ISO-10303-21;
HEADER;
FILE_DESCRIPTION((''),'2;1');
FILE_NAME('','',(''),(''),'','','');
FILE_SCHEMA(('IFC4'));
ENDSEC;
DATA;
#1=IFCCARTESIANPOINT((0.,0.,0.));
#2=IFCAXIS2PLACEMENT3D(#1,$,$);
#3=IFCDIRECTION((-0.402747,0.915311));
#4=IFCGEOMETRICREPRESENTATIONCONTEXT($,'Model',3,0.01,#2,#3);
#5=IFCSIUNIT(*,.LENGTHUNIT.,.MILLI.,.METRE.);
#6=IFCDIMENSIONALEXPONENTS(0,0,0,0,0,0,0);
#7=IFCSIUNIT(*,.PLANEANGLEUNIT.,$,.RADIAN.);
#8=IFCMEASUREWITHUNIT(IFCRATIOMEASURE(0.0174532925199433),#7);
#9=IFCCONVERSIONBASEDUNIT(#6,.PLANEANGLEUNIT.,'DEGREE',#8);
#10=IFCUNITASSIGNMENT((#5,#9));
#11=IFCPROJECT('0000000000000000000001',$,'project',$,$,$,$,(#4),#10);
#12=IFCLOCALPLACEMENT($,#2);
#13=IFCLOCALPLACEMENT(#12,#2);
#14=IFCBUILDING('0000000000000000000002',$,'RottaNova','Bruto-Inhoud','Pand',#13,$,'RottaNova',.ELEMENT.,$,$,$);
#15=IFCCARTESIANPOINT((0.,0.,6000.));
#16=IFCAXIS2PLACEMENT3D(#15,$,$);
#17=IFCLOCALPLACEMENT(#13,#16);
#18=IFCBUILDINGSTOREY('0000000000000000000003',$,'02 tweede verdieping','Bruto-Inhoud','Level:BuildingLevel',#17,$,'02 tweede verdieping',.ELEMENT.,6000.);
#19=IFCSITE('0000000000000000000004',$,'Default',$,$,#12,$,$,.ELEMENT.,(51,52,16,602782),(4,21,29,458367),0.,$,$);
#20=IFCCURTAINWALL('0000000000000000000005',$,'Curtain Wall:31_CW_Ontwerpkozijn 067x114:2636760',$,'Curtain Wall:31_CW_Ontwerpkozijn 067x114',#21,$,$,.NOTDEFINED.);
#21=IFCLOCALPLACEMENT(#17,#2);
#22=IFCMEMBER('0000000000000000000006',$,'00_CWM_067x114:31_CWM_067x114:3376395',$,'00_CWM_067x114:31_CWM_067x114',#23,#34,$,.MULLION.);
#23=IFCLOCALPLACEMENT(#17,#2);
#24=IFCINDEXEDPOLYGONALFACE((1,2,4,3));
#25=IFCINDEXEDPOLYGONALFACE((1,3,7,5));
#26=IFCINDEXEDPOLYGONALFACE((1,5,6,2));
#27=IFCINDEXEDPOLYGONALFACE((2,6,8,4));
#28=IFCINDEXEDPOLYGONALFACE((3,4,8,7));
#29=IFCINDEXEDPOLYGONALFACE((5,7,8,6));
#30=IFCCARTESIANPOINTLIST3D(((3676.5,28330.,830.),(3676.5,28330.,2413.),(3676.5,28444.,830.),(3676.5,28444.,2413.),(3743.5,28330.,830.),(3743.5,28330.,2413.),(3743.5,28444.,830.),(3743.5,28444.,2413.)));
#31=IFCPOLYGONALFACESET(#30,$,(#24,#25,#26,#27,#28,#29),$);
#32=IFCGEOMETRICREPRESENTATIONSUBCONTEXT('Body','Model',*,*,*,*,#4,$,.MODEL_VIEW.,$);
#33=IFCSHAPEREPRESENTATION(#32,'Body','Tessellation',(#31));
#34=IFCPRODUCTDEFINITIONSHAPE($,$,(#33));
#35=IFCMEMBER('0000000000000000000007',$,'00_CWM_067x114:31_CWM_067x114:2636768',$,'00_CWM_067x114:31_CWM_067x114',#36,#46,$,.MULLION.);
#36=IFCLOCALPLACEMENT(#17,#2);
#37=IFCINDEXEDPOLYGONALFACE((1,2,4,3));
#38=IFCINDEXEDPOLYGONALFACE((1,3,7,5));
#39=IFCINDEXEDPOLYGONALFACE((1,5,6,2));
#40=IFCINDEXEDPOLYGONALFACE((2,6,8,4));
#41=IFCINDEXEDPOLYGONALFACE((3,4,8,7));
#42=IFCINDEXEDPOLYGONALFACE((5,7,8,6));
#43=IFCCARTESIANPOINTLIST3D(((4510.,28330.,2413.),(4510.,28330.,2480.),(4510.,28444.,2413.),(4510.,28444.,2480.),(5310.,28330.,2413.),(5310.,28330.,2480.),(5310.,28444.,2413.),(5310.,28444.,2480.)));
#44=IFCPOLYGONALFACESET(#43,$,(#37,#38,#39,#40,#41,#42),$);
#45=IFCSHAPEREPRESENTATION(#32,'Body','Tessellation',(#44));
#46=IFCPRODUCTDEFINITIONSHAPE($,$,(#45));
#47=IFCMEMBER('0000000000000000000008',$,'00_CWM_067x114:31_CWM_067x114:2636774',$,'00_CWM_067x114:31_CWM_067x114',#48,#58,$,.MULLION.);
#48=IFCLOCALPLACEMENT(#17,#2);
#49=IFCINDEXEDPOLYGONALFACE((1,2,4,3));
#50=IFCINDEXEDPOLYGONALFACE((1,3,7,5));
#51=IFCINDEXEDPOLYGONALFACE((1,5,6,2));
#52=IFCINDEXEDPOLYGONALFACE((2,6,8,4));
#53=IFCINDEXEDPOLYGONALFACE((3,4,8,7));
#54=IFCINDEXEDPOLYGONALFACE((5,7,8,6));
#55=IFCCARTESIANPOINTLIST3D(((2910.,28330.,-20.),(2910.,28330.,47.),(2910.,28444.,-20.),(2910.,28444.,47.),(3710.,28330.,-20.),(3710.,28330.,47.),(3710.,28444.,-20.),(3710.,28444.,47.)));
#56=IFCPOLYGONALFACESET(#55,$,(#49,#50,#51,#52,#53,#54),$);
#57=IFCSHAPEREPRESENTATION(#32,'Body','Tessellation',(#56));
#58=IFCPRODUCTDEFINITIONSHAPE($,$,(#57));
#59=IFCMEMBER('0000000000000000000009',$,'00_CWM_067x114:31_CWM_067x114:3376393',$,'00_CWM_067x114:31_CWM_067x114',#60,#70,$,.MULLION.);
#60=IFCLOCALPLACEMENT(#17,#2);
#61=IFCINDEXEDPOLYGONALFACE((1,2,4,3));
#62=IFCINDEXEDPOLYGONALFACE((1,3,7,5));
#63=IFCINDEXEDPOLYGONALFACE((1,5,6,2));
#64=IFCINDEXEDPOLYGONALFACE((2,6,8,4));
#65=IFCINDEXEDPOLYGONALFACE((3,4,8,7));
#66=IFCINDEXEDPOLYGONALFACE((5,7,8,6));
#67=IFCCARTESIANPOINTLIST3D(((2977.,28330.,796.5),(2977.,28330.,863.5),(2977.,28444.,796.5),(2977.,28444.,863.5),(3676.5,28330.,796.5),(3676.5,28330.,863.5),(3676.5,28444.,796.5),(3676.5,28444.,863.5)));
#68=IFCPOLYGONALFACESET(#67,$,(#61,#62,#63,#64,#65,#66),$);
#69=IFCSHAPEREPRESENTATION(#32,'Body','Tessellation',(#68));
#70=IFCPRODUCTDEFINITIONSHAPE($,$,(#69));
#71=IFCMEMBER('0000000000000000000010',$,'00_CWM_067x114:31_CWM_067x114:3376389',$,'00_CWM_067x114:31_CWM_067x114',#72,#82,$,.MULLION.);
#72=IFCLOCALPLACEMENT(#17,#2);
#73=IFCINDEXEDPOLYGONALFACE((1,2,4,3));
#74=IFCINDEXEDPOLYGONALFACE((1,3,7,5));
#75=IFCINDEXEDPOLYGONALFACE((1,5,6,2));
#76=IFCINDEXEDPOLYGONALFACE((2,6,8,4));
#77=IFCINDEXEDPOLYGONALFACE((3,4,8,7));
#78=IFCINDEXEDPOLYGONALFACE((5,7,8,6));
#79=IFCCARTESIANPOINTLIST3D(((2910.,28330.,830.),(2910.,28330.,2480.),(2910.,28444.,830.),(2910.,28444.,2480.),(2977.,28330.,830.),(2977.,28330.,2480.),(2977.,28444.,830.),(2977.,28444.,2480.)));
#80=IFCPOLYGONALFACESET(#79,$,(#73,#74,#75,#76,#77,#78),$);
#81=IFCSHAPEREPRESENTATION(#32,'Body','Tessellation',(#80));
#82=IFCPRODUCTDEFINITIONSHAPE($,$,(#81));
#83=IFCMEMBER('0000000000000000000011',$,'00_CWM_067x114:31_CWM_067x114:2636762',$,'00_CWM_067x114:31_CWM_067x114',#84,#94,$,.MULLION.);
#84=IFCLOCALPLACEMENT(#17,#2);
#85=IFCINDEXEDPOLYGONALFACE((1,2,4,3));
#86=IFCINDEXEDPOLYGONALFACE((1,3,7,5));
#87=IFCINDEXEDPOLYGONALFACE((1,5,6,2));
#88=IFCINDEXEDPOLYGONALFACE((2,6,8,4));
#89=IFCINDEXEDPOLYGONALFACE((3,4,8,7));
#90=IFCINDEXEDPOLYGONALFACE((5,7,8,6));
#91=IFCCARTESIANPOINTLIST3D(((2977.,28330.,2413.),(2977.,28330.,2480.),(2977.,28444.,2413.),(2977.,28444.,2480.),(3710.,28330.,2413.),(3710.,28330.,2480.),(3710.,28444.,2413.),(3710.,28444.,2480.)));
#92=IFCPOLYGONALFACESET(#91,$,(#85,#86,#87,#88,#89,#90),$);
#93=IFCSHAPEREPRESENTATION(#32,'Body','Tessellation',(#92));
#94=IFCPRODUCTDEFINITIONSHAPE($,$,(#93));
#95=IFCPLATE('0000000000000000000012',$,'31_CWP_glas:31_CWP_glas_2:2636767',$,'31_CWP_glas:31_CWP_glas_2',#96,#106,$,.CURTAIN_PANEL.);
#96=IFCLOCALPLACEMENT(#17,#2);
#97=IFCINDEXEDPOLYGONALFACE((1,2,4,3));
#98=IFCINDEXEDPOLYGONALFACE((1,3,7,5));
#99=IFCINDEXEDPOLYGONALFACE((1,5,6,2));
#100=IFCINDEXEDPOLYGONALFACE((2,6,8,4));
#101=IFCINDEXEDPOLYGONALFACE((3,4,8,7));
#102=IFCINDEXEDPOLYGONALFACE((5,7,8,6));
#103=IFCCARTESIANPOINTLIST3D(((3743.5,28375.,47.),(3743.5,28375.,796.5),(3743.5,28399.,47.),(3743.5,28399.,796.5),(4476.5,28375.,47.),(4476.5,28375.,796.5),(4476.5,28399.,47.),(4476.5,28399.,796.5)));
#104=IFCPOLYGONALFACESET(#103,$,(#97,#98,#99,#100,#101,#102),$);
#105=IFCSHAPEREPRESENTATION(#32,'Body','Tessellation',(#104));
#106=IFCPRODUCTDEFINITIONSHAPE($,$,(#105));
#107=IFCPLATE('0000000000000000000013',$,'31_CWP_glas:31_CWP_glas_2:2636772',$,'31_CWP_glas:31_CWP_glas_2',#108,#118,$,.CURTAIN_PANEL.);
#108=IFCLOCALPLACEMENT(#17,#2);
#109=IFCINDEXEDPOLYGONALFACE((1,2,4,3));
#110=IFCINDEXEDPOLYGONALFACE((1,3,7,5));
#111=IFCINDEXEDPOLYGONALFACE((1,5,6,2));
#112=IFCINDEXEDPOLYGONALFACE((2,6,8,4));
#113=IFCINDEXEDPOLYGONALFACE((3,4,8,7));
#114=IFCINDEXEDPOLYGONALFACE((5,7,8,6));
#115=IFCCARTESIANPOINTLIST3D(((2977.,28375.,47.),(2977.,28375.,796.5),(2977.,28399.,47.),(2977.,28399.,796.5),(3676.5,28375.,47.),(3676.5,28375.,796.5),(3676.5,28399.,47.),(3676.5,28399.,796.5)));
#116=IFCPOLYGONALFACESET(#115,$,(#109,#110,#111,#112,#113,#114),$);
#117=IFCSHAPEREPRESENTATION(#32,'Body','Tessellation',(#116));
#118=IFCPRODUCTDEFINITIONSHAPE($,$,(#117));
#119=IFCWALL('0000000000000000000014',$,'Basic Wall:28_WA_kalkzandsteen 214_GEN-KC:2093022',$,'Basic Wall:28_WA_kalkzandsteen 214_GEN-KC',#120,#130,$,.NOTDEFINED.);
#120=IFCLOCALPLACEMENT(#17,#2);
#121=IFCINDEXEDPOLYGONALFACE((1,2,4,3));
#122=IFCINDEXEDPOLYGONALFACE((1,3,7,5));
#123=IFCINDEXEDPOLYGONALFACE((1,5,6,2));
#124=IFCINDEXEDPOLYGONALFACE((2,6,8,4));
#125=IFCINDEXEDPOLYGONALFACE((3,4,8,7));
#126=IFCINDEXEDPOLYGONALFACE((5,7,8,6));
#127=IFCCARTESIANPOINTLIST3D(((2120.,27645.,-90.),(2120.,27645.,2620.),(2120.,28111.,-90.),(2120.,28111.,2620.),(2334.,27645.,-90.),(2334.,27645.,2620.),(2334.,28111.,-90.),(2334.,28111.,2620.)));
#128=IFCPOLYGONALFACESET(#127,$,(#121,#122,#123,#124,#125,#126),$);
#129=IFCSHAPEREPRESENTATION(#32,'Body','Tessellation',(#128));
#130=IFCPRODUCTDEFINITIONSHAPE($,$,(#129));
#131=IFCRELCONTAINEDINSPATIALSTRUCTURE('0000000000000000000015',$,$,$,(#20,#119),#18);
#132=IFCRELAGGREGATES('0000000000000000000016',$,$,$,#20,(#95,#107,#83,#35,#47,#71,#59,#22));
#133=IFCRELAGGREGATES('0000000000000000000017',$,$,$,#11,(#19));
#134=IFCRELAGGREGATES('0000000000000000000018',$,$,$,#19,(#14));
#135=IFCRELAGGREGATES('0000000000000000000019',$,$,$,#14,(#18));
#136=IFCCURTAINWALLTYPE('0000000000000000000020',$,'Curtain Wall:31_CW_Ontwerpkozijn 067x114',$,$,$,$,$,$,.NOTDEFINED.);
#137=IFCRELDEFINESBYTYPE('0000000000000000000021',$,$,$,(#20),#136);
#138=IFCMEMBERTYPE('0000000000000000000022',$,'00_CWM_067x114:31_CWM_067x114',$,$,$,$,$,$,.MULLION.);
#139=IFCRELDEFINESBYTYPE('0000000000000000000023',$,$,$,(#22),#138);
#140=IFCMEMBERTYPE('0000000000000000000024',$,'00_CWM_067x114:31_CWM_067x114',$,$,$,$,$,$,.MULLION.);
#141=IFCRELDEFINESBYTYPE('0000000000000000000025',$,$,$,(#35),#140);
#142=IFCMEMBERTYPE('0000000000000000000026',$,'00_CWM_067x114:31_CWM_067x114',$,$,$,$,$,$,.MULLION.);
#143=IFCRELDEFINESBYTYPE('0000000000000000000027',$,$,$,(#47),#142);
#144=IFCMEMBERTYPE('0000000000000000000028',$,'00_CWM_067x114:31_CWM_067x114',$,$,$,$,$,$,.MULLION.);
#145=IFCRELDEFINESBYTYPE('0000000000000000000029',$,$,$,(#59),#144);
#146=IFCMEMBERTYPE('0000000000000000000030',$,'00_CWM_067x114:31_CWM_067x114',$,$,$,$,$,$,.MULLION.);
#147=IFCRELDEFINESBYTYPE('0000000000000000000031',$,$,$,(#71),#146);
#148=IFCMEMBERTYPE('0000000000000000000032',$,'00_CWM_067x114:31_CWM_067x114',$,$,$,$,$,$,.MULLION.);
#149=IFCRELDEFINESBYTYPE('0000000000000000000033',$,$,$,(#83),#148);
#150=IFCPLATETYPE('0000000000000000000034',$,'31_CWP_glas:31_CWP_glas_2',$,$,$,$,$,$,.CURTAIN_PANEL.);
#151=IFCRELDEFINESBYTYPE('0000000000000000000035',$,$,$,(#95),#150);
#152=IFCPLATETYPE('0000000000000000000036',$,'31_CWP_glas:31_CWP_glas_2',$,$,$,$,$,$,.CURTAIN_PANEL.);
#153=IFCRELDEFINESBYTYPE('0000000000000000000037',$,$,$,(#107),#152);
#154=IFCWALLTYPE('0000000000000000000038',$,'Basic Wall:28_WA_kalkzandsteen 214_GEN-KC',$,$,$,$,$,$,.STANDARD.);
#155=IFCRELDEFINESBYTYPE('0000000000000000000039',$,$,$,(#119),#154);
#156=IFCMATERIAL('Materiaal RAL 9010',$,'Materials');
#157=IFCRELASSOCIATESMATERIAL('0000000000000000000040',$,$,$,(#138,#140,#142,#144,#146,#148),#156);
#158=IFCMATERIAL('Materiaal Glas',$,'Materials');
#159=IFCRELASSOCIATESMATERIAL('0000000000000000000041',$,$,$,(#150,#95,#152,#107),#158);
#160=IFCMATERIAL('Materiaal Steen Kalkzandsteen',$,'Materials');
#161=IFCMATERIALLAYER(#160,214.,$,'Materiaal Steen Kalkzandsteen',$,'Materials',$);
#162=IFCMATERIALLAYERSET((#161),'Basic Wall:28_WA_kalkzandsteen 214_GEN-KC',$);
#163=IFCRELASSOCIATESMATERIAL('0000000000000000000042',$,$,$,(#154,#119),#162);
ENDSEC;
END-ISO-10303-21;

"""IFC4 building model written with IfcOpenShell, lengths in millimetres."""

from ifc_helpers import new_model, entity, si_unit, converted_unit, direction, frame, frame_2d, origin, origin_2d_with_axis, place, context, subcontext, project, spatial, rectangle, extrude, source, transform, mapped, material, layer, layer_set, material_profile, profile_set, type_object, type_shapes, element, aggregate, save


model = new_model("IFC4")

# Units and contexts
model_context = context("Model", 3, precision=0.01, world=origin(), true_north=direction((-0.402747, 0.915311)))
body_context = subcontext(model_context, "Body", "Model", "MODEL_VIEW")
ifc_project = project(units=[si_unit("LENGTHUNIT", "METRE", prefix="MILLI"), converted_unit("PLANEANGLEUNIT", "DEGREE", entity("IfcRatioMeasure", 0.0174532925199433), si_unit("PLANEANGLEUNIT", "RADIAN"), dimensions=[0, 0, 0, 0, 0, 0, 0])], contexts=[model_context])

# Site, building, storey
site_placement = place(None, origin())
site = spatial("IfcSite", under=ifc_project, at=site_placement, Name="Default", CompositionType="ELEMENT", RefLatitude=(51, 52, 16, 602782), RefLongitude=(4, 21, 29, 458367), RefElevation=0.0)
building_placement = place(site_placement, origin())
building = spatial("IfcBuilding", under=site, at=building_placement, Name="RottaNova", Description="Bruto-Inhoud", ObjectType="Pand", LongName="RottaNova", CompositionType="ELEMENT")
storey_placement = place(building_placement, frame((0.0, 0.0, 6000.0)))
storey = spatial("IfcBuildingStorey", under=building, at=storey_placement, Name="02 tweede verdieping", Description="Bruto-Inhoud", ObjectType="Level:BuildingLevel", LongName="02 tweede verdieping", CompositionType="ELEMENT", Elevation=6000.0)

# Shared definitions
curtain_wall_type = type_object("IfcCurtainWallType", Name="Curtain Wall:31_CW_Ontwerpkozijn 067x114", PredefinedType="NOTDEFINED")

# Curtain wall, members, plates
curtain_wall_1_placement = place(storey_placement, frame((0.0, 0.0, -6000.0)))
curtain_wall_1 = element("IfcCurtainWall", 1, at=curtain_wall_1_placement, inside=storey, type_object=curtain_wall_type, Name="Curtain Wall:31_CW_Ontwerpkozijn 067x114:2636760", ObjectType="Curtain Wall:31_CW_Ontwerpkozijn 067x114", PredefinedType="NOTDEFINED")
ifc_material_1 = material(Name="Materiaal RAL 9010", Category="Materials")
ifc_material_profile_1 = material_profile(ifc_material_1, rectangle(XDim=114.0, YDim=67.0, at=origin_2d_with_axis()), Name="31_CWM_067x114")
ifc_profile_set_1 = profile_set([ifc_material_profile_1], Name="31_CWM_067x114")
member_type_1 = type_object("IfcMemberType", Name="00_CWM_067x114:31_CWM_067x114", PredefinedType="MULLION", material=ifc_profile_set_1)
shared_shape_1 = source(origin(), body_context, "Body", "SweptSolid", [
    extrude(rectangle(XDim=114.0, YDim=67.0, at=origin_2d_with_axis()), frame((0.0, 57.0, -1583.0), z_axis=(0.0, 0.0, 1.0), x_axis=(0.0, -1.0, 0.0)), (0.0, 0.0, 1.0), 1583.0),
])
type_shapes(member_type_1, [shared_shape_1])
member_1_placement = place(curtain_wall_1_placement, frame((3710.0, 28330.0, 6830.0), z_axis=(0.0, 0.0, -1.0), x_axis=(-1.0, 0.0, 0.0)))
member_1 = element("IfcMember", 2, at=member_1_placement, type_object=member_type_1, Name="00_CWM_067x114:31_CWM_067x114:3376395", ObjectType="00_CWM_067x114:31_CWM_067x114", PredefinedType="MULLION", context=body_context, shape_type="MappedRepresentation", body=[
    mapped(shared_shape_1, transform((0.0, 0.0, 0.0), scale=1.0)),
])
member_type_2 = type_object("IfcMemberType", Name="00_CWM_067x114:31_CWM_067x114", PredefinedType="MULLION", material=ifc_profile_set_1)
shared_shape_2 = source(origin(), body_context, "Body", "SweptSolid", [
    extrude(rectangle(XDim=114.0, YDim=67.0, at=origin_2d_with_axis()), frame((-33.5, 57.0, -800.0), z_axis=(0.0, 0.0, 1.0), x_axis=(0.0, -1.0, 0.0)), (0.0, 0.0, 1.0), 800.0),
])
type_shapes(member_type_2, [shared_shape_2])
member_2_placement = place(curtain_wall_1_placement, frame((4510.0, 28330.0, 8480.0), z_axis=(-1.0, 0.0, 0.0), x_axis=(0.0, 0.0, 1.0)))
member_2 = element("IfcMember", 3, at=member_2_placement, type_object=member_type_2, Name="00_CWM_067x114:31_CWM_067x114:2636768", ObjectType="00_CWM_067x114:31_CWM_067x114", PredefinedType="MULLION", context=body_context, shape_type="MappedRepresentation", body=[
    mapped(shared_shape_2, transform((0.0, 0.0, 0.0), scale=1.0)),
])
member_type_3 = type_object("IfcMemberType", Name="00_CWM_067x114:31_CWM_067x114", PredefinedType="MULLION", material=ifc_profile_set_1)
shared_shape_3 = source(origin(), body_context, "Body", "SweptSolid", [
    extrude(rectangle(XDim=114.0, YDim=67.0, at=origin_2d_with_axis()), frame((-33.5, 57.0, -800.0), z_axis=(0.0, 0.0, 1.0), x_axis=(0.0, -1.0, 0.0)), (0.0, 0.0, 1.0), 800.0),
])
type_shapes(member_type_3, [shared_shape_3])
member_3_placement = place(curtain_wall_1_placement, frame((3710.0, 28330.0, 5980.0), z_axis=(1.0, 0.0, 0.0), x_axis=(0.0, 0.0, -1.0)))
member_3 = element("IfcMember", 4, at=member_3_placement, type_object=member_type_3, Name="00_CWM_067x114:31_CWM_067x114:2636774", ObjectType="00_CWM_067x114:31_CWM_067x114", PredefinedType="MULLION", context=body_context, shape_type="MappedRepresentation", body=[
    mapped(shared_shape_3, transform((0.0, 0.0, 0.0), scale=1.0)),
])
member_type_4 = type_object("IfcMemberType", Name="00_CWM_067x114:31_CWM_067x114", PredefinedType="MULLION", material=ifc_profile_set_1)
shared_shape_4 = source(origin(), body_context, "Body", "SweptSolid", [
    extrude(rectangle(XDim=114.0, YDim=67.0, at=origin_2d_with_axis()), frame((0.0, 57.0, -699.5), z_axis=(0.0, 0.0, 1.0), x_axis=(0.0, -1.0, 0.0)), (0.0, 0.0, 1.0), 699.5),
])
type_shapes(member_type_4, [shared_shape_4])
member_4_placement = place(curtain_wall_1_placement, frame((2977.0, 28330.0, 6830.0), z_axis=(-1.0, 0.0, 0.0), x_axis=(0.0, 0.0, 1.0)))
member_4 = element("IfcMember", 5, at=member_4_placement, type_object=member_type_4, Name="00_CWM_067x114:31_CWM_067x114:3376393", ObjectType="00_CWM_067x114:31_CWM_067x114", PredefinedType="MULLION", context=body_context, shape_type="MappedRepresentation", body=[
    mapped(shared_shape_4, transform((0.0, 0.0, 0.0), scale=1.0)),
])
member_type_5 = type_object("IfcMemberType", Name="00_CWM_067x114:31_CWM_067x114", PredefinedType="MULLION", material=ifc_profile_set_1)
shared_shape_5 = source(origin(), body_context, "Body", "SweptSolid", [
    extrude(rectangle(XDim=114.0, YDim=67.0, at=origin_2d_with_axis()), frame((-33.5, 57.0, -1650.0), z_axis=(0.0, 0.0, 1.0), x_axis=(0.0, -1.0, 0.0)), (0.0, 0.0, 1.0), 1650.0),
])
type_shapes(member_type_5, [shared_shape_5])
member_5_placement = place(curtain_wall_1_placement, frame((2910.0, 28330.0, 6830.0), z_axis=(0.0, 0.0, -1.0), x_axis=(-1.0, 0.0, 0.0)))
member_5 = element("IfcMember", 6, at=member_5_placement, type_object=member_type_5, Name="00_CWM_067x114:31_CWM_067x114:3376389", ObjectType="00_CWM_067x114:31_CWM_067x114", PredefinedType="MULLION", context=body_context, shape_type="MappedRepresentation", body=[
    mapped(shared_shape_5, transform((0.0, 0.0, 0.0), scale=1.0)),
])
member_type_6 = type_object("IfcMemberType", Name="00_CWM_067x114:31_CWM_067x114", PredefinedType="MULLION", material=ifc_profile_set_1)
shared_shape_6 = source(origin(), body_context, "Body", "SweptSolid", [
    extrude(rectangle(XDim=114.0, YDim=67.0, at=origin_2d_with_axis()), frame((-33.5, 57.0, -733.0), z_axis=(0.0, 0.0, 1.0), x_axis=(0.0, -1.0, 0.0)), (0.0, 0.0, 1.0), 733.0),
])
type_shapes(member_type_6, [shared_shape_6])
member_6_placement = place(curtain_wall_1_placement, frame((2977.0, 28330.0, 8480.0), z_axis=(-1.0, 0.0, 0.0), x_axis=(0.0, 0.0, 1.0)))
member_6 = element("IfcMember", 7, at=member_6_placement, type_object=member_type_6, Name="00_CWM_067x114:31_CWM_067x114:2636762", ObjectType="00_CWM_067x114:31_CWM_067x114", PredefinedType="MULLION", context=body_context, shape_type="MappedRepresentation", body=[
    mapped(shared_shape_6, transform((0.0, 0.0, 0.0), scale=1.0)),
])
ifc_material_2 = material(Name="Materiaal Glas", Category="Materials")
plate_type_1 = type_object("IfcPlateType", Name="31_CWP_glas:31_CWP_glas_2", PredefinedType="CURTAIN_PANEL", material=ifc_material_2)
shared_shape_7 = source(origin(), body_context, "Body", "SweptSolid", [
    extrude(rectangle(XDim=24.0, YDim=733.0, at=frame_2d((0.0, 0.0), x_axis=(1.0, 0.0))), frame((366.5, 12.0, 0.0), z_axis=(0.0, 0.0, 1.0), x_axis=(0.0, 1.0, 0.0)), (0.0, 0.0, 1.0), 749.5),
])
type_shapes(plate_type_1, [shared_shape_7])
plate_1_placement = place(curtain_wall_1_placement, frame((4476.5, 28399.0, 6047.0), z_axis=(0.0, 0.0, 1.0), x_axis=(-1.0, 0.0, 0.0)))
plate_1 = element("IfcPlate", 8, at=plate_1_placement, type_object=plate_type_1, material=ifc_material_2, Name="31_CWP_glas:31_CWP_glas_2:2636767", ObjectType="31_CWP_glas:31_CWP_glas_2", PredefinedType="CURTAIN_PANEL", context=body_context, shape_type="MappedRepresentation", body=[
    mapped(shared_shape_7, transform((0.0, 0.0, 0.0), scale=1.0)),
])
plate_type_2 = type_object("IfcPlateType", Name="31_CWP_glas:31_CWP_glas_2", PredefinedType="CURTAIN_PANEL", material=ifc_material_2)
shared_shape_8 = source(origin(), body_context, "Body", "SweptSolid", [
    extrude(rectangle(XDim=24.0, YDim=699.5, at=frame_2d((0.0, 0.0), x_axis=(1.0, 0.0))), frame((349.8, 12.0, 0.0), z_axis=(0.0, 0.0, 1.0), x_axis=(0.0, 1.0, 0.0)), (0.0, 0.0, 1.0), 749.5),
])
type_shapes(plate_type_2, [shared_shape_8])
plate_2_placement = place(curtain_wall_1_placement, frame((3676.5, 28399.0, 6047.0), z_axis=(0.0, 0.0, 1.0), x_axis=(-1.0, 0.0, 0.0)))
plate_2 = element("IfcPlate", 9, at=plate_2_placement, type_object=plate_type_2, material=ifc_material_2, Name="31_CWP_glas:31_CWP_glas_2:2636772", ObjectType="31_CWP_glas:31_CWP_glas_2", PredefinedType="CURTAIN_PANEL", context=body_context, shape_type="MappedRepresentation", body=[
    mapped(shared_shape_8, transform((0.0, 0.0, 0.0), scale=1.0)),
])

# Shared definitions
ifc_material_3 = material(Name="Materiaal Steen Kalkzandsteen", Category="Materials")
ifc_layer_1 = layer(ifc_material_3, 214.0, Name="Materiaal Steen Kalkzandsteen", Category="Materials")
ifc_layer_set_1 = layer_set([ifc_layer_1], Name="Basic Wall:28_WA_kalkzandsteen 214_GEN-KC")
wall_type_1 = type_object("IfcWallType", Name="Basic Wall:28_WA_kalkzandsteen 214_GEN-KC", PredefinedType="STANDARD", material=ifc_layer_set_1)

# Wall
wall_1_placement = place(storey_placement, frame((2227.0, 28111.0, -90.0), z_axis=(0.0, 0.0, 1.0), x_axis=(0.0, -1.0, 0.0)))
element("IfcWall", 10, at=wall_1_placement, inside=storey, type_object=wall_type_1, material=ifc_layer_set_1, Name="Basic Wall:28_WA_kalkzandsteen 214_GEN-KC:2093022", ObjectType="Basic Wall:28_WA_kalkzandsteen 214_GEN-KC", PredefinedType="NOTDEFINED", context=body_context, shape_type="SweptSolid", body=[
    extrude(rectangle(XDim=466.0, YDim=214.0, at=frame_2d((233.0, 0.0), x_axis=(-1.0, 0.0))), origin(), (0.0, 0.0, 1.0), 2710.0),
])

aggregate(curtain_wall_1, [plate_1, plate_2, member_6, member_2, member_3, member_5, member_4, member_1])

save(model, "model.ifc")
